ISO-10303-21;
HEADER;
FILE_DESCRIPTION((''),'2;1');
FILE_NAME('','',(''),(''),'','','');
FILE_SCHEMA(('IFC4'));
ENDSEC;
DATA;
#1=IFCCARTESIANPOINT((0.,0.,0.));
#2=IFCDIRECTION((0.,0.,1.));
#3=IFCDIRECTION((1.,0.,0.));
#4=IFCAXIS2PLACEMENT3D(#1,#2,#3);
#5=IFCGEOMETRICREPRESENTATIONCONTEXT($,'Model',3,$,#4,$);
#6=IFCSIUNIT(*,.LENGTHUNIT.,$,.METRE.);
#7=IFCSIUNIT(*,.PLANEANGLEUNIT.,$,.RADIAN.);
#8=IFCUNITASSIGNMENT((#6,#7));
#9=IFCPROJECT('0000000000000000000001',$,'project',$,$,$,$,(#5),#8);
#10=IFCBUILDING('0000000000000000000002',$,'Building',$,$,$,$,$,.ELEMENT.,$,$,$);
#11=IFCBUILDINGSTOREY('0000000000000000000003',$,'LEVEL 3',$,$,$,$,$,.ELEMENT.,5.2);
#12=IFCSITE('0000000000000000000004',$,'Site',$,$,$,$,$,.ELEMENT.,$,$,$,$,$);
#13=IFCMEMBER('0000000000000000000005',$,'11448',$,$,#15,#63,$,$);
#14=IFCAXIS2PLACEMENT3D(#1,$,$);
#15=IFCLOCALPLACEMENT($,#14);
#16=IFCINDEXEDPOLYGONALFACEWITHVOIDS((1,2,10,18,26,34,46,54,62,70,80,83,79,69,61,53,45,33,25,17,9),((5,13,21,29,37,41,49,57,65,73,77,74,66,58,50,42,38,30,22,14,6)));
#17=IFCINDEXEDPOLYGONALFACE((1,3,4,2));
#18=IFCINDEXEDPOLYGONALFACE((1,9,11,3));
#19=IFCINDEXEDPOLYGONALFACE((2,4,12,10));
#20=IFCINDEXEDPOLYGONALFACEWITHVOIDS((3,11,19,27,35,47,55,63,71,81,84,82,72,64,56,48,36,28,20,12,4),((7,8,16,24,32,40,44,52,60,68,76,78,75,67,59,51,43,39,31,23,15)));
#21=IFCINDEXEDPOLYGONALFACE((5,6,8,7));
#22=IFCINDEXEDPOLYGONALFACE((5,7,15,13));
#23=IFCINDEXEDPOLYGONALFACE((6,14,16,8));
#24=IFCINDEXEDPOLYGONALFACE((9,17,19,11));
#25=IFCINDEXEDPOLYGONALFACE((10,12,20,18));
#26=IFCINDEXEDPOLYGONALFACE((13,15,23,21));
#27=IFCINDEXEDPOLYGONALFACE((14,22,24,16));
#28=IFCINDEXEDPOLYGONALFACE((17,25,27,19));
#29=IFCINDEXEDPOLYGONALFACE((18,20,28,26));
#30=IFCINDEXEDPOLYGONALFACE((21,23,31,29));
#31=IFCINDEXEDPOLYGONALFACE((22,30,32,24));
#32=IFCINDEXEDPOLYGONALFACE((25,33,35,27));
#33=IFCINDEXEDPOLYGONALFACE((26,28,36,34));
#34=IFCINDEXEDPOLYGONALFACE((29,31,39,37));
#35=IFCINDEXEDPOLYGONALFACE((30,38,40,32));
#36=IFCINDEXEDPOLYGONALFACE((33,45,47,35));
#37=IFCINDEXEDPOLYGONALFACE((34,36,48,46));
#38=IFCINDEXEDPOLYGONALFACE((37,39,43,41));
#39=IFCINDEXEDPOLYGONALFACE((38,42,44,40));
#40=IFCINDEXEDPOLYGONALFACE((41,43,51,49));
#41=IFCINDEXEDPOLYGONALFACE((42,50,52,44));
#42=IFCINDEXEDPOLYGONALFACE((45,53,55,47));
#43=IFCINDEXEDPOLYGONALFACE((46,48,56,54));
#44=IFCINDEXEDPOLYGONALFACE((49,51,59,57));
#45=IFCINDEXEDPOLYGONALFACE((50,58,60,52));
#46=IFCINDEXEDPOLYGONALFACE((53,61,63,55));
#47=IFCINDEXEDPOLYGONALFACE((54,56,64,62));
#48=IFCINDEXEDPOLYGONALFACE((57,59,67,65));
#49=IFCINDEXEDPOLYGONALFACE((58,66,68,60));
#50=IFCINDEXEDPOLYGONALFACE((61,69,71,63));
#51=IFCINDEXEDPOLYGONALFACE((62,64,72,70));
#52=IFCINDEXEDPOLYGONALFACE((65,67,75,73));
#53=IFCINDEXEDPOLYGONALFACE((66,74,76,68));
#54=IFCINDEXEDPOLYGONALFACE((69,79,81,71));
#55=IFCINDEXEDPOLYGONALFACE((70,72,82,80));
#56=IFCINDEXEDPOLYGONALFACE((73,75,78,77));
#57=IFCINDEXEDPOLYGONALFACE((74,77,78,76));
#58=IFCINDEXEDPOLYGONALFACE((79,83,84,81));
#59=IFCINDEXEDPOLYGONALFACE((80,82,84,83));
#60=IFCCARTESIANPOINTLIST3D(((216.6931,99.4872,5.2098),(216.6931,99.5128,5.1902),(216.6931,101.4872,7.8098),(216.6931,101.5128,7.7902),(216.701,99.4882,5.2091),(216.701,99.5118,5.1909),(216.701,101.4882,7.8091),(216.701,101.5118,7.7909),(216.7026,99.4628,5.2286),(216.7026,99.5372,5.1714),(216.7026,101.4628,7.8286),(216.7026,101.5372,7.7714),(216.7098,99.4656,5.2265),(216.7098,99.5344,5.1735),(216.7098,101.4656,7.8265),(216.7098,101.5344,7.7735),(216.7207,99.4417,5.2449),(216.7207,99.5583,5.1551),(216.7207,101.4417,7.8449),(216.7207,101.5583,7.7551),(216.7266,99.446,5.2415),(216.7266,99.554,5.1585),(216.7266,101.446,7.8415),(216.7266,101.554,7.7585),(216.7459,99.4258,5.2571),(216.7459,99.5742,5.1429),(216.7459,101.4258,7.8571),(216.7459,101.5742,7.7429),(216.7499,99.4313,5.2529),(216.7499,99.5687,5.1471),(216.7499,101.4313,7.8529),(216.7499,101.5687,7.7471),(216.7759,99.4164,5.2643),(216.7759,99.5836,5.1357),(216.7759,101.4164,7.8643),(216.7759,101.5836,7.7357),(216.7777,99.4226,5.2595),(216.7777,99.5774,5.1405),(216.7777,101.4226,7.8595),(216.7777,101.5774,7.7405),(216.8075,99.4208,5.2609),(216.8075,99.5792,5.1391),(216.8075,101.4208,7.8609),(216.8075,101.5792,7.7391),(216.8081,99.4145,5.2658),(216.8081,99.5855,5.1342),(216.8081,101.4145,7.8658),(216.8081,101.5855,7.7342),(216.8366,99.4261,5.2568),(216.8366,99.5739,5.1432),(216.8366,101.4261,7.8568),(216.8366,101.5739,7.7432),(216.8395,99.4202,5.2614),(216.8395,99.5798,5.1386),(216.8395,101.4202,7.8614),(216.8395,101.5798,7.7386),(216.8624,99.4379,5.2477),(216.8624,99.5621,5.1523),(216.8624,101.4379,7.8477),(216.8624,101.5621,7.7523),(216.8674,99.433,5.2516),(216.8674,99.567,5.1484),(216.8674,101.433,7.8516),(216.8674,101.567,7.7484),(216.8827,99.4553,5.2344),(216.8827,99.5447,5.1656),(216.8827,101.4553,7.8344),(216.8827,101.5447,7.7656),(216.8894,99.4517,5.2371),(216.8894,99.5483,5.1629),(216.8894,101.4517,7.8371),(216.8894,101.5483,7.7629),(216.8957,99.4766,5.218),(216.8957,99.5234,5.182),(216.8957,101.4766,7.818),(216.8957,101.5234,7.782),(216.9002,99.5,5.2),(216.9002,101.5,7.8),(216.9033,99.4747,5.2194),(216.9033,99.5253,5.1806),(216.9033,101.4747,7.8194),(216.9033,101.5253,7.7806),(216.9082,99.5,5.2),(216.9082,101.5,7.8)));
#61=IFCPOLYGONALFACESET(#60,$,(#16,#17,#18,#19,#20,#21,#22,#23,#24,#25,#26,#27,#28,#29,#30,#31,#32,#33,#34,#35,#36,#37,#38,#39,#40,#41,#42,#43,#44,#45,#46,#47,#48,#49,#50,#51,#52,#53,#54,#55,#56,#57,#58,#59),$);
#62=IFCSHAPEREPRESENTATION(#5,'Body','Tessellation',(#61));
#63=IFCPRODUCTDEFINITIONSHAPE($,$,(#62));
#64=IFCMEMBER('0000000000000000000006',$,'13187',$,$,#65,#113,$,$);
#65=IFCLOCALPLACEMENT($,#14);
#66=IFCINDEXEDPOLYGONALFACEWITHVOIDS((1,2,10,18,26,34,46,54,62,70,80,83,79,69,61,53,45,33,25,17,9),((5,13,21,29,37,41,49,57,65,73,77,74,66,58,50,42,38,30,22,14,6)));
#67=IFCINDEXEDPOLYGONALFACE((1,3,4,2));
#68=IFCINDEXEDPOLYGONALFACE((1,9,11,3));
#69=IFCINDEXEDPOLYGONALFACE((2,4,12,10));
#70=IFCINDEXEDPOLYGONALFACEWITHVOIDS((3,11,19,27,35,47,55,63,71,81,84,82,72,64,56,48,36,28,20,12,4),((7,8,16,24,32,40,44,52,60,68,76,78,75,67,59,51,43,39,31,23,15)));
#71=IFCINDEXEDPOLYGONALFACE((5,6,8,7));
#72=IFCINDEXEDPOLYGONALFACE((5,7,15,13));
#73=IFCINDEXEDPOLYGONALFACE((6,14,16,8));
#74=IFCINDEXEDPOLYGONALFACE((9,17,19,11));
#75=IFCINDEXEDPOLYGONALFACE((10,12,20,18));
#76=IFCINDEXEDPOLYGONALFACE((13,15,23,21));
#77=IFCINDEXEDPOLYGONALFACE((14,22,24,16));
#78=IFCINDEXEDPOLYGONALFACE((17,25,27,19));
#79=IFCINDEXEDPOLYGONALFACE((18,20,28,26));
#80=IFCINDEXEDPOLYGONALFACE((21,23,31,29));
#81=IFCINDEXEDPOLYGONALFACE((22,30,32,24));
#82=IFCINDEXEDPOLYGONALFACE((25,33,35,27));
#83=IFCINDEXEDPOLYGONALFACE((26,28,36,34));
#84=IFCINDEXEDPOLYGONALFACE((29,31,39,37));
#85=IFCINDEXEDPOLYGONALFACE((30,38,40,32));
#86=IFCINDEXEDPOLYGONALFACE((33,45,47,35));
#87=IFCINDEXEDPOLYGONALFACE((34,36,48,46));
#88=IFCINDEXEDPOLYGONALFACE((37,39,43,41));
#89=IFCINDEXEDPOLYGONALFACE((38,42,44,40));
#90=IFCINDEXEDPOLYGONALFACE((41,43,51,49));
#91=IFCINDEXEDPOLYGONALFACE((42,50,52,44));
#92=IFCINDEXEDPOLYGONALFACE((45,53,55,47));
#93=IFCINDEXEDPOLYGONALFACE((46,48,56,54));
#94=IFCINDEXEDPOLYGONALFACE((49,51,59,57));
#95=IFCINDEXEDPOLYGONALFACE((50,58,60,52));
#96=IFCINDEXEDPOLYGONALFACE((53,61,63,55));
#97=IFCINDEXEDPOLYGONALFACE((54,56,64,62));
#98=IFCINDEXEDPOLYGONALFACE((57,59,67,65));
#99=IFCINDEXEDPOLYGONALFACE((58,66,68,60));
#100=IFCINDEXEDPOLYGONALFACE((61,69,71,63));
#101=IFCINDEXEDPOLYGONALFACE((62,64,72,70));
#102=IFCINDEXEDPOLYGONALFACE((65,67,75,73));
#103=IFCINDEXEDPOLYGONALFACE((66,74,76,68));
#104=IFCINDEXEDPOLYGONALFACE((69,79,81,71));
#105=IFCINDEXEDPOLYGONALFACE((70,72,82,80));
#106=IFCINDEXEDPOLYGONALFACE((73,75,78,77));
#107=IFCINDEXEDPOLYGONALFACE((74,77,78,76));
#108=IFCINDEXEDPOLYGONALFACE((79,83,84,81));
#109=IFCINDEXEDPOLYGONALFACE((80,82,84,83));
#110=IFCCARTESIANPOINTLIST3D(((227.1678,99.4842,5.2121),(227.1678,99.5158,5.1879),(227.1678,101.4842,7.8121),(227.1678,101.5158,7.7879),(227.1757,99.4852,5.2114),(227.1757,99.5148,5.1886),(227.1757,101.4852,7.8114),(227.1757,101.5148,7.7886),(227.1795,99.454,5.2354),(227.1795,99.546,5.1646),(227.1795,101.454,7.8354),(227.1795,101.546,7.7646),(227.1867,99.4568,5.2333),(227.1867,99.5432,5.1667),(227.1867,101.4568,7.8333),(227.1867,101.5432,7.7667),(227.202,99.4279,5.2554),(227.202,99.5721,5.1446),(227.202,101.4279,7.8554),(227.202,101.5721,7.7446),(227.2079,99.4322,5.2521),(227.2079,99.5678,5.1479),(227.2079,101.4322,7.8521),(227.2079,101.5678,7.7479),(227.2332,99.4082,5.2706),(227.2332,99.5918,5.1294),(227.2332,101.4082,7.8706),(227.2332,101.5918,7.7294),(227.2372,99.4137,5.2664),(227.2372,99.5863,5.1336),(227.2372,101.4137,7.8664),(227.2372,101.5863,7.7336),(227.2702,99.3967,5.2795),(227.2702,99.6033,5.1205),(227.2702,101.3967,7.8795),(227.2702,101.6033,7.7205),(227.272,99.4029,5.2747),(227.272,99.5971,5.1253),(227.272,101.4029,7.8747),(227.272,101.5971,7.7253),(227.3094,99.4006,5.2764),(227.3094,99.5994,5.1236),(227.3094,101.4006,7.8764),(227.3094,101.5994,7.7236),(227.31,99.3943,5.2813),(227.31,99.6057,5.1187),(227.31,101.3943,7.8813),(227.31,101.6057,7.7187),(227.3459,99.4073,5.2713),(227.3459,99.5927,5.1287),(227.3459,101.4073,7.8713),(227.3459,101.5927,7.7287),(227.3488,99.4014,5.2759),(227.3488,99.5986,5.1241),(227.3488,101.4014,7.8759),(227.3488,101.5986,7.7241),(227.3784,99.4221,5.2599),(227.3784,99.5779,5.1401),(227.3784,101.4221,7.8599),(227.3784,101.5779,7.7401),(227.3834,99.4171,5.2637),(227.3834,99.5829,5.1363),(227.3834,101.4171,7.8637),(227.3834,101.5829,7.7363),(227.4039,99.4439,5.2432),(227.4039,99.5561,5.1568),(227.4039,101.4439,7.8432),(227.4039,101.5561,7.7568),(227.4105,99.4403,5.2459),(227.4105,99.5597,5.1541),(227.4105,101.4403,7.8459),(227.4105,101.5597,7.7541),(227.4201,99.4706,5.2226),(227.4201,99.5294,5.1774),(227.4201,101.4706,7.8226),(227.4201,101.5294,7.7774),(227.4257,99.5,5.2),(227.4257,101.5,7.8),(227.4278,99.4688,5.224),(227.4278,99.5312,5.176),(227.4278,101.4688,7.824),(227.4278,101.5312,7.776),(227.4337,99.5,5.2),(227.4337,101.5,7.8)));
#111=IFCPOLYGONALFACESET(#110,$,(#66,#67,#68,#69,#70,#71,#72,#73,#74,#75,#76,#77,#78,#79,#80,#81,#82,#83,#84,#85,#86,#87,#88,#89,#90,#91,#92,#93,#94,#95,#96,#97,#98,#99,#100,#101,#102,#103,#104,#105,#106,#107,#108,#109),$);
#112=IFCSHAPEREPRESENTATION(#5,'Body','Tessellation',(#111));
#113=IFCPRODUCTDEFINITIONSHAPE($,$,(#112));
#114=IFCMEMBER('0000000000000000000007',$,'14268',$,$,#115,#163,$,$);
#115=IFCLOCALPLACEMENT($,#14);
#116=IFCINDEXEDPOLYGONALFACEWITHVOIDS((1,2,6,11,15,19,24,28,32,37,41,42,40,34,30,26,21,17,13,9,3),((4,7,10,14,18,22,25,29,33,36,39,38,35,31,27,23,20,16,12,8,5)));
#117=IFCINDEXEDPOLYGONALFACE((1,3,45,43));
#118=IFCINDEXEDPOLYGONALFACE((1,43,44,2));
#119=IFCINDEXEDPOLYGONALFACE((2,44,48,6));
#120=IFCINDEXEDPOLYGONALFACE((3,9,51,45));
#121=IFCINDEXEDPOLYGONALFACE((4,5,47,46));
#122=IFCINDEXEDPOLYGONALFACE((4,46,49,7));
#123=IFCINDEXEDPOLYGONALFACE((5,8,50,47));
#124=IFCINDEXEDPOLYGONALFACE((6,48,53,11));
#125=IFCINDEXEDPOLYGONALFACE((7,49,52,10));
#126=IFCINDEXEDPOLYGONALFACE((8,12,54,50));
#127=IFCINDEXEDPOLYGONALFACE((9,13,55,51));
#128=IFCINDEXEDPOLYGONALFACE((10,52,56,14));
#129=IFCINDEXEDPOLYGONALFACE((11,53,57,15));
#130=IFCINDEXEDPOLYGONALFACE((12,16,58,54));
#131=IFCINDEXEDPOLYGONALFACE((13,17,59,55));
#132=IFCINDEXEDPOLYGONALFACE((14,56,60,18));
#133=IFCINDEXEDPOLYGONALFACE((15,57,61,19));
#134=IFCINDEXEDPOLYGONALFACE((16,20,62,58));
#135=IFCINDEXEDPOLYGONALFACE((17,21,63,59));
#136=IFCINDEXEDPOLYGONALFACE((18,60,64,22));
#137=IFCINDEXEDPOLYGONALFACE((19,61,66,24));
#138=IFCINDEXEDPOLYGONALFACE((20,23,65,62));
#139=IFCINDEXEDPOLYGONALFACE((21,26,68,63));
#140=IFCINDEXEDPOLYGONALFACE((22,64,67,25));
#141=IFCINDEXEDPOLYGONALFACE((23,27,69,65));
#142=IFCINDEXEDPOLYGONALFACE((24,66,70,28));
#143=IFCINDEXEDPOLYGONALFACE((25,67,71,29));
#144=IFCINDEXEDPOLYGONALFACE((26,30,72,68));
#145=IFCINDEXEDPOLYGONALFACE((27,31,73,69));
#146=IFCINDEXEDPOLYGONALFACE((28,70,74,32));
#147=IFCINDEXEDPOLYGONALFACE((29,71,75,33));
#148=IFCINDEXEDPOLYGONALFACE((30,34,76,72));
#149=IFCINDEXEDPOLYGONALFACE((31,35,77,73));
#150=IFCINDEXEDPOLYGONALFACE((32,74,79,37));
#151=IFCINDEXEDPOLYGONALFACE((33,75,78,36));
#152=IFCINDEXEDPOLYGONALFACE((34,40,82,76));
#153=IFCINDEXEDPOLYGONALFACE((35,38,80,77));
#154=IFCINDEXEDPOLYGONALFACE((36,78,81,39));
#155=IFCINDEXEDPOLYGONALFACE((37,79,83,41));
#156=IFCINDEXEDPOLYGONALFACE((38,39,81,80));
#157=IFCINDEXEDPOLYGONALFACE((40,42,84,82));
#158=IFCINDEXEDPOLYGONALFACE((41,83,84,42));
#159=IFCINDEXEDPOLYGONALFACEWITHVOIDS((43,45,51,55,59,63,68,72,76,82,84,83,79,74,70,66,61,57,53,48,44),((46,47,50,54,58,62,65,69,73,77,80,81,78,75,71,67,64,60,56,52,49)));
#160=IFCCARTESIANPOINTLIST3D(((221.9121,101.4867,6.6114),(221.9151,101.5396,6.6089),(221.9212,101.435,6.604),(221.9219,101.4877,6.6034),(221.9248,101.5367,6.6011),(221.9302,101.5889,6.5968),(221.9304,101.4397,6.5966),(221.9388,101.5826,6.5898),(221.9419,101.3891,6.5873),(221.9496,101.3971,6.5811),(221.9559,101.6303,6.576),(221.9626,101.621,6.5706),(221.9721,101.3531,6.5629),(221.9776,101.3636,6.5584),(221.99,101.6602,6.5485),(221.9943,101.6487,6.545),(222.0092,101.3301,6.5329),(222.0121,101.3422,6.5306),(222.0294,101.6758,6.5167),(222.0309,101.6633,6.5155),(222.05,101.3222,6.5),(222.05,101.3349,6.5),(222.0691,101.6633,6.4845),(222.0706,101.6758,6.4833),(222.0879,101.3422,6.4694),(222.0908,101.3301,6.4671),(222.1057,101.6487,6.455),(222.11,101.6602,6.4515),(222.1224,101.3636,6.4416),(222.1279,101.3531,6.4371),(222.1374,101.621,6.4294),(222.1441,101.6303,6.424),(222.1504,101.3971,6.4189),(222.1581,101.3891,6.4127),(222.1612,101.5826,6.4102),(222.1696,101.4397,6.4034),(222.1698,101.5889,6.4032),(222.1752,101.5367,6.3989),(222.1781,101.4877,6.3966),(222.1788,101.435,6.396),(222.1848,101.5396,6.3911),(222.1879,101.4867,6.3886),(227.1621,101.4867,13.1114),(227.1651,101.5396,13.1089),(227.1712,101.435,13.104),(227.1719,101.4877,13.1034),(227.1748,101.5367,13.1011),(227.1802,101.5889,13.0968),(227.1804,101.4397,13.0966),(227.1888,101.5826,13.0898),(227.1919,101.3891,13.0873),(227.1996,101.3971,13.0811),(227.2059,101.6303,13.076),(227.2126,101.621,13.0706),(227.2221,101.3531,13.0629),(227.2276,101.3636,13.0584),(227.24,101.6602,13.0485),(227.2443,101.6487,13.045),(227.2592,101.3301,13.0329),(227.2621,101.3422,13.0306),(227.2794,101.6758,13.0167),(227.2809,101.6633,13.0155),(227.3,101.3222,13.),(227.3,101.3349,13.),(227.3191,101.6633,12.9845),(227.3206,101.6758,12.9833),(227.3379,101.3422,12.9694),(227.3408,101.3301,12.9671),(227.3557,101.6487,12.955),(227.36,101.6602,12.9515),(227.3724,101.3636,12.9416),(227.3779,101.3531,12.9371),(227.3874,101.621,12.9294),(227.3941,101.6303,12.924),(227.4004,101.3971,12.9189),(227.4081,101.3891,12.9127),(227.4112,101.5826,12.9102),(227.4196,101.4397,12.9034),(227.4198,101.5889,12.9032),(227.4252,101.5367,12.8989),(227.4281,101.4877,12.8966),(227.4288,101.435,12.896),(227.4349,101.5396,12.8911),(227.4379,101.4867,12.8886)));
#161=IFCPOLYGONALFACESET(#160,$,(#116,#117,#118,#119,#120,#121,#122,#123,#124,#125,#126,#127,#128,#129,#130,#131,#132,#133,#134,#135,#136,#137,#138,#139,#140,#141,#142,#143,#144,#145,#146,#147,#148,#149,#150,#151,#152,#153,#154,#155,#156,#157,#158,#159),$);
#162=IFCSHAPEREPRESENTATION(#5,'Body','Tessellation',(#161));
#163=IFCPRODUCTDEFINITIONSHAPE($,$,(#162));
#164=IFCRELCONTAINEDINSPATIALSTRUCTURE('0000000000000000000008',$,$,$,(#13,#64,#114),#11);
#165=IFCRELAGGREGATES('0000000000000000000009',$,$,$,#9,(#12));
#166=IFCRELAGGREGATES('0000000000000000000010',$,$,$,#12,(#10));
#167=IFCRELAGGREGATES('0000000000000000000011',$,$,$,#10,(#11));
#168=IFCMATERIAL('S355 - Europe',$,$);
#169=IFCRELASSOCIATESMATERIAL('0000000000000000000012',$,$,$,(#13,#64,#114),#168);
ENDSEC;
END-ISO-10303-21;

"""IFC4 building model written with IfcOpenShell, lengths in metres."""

from ifc_helpers import new_model, si_unit, frame, origin_with_axes, origin_2d_with_axis, place, context, project, spatial, hollow_circle, extrude, material, material_profile, profile_set, profile_usage, element, save


model = new_model("IFC4")

# Units and contexts
model_context = context("Model", 3, world=origin_with_axes())
ifc_project = project(units=[si_unit("LENGTHUNIT", "METRE"), si_unit("PLANEANGLEUNIT", "RADIAN")], contexts=[model_context])

# Site, building, storey
site = spatial("IfcSite", under=ifc_project, Name="Site", CompositionType="ELEMENT")
building = spatial("IfcBuilding", under=site, Name="Building", CompositionType="ELEMENT")
storey = spatial("IfcBuildingStorey", under=building, Name="LEVEL 3", CompositionType="ELEMENT", Elevation=5.2)

# Shared definitions
ifc_material = material(Name="S355 - Europe")

# Members
ifc_material_profile_1 = material_profile(ifc_material, hollow_circle(Radius=0.1081, WallThickness=0.008, at=origin_2d_with_axis()))
ifc_profile_set_1 = profile_set([ifc_material_profile_1])
ifc_profile_usage_1 = profile_usage(ifc_profile_set_1, cardinal=10)
member_1_placement = place(None, frame((216.8, 101.5, 7.8), z_axis=(0.0, -0.609711, -0.792624), x_axis=(1.0, 0.0, 0.0)))
element("IfcMember", 1, at=member_1_placement, inside=storey, material=ifc_profile_usage_1, Name="11448", context=model_context, shape_type="SweptSolid", body=[
    extrude(hollow_circle(Radius=0.1081, WallThickness=0.008, at=origin_2d_with_axis()), origin_with_axes(), (0.0, 0.0, 1.0), 3.2802),
])
ifc_material_profile_2 = material_profile(ifc_material, hollow_circle(Radius=0.1337, WallThickness=0.008, at=origin_2d_with_axis()))
ifc_profile_set_2 = profile_set([ifc_material_profile_2])
ifc_profile_usage_2 = profile_usage(ifc_profile_set_2, cardinal=10)
member_2_placement = place(None, frame((227.3, 101.5, 7.8), z_axis=(0.0, -0.609711, -0.792624), x_axis=(1.0, 0.0, 0.0)))
element("IfcMember", 2, at=member_2_placement, inside=storey, material=ifc_profile_usage_2, Name="13187", context=model_context, shape_type="SweptSolid", body=[
    extrude(hollow_circle(Radius=0.1337, WallThickness=0.008, at=origin_2d_with_axis()), origin_with_axes(), (0.0, 0.0, 1.0), 3.2802),
])
ifc_material_profile_3 = material_profile(ifc_material, hollow_circle(Radius=0.1778, WallThickness=0.0127, at=origin_2d_with_axis()))
ifc_profile_set_3 = profile_set([ifc_material_profile_3])
ifc_profile_usage_3 = profile_usage(ifc_profile_set_3, cardinal=10)
member_3_placement = place(None, frame((227.3, 101.5, 13.0), z_axis=(-0.628337, 0.0, -0.777941), x_axis=(0.0, -1.0, 0.0)))
element("IfcMember", 3, at=member_3_placement, inside=storey, material=ifc_profile_usage_3, Name="14268", context=model_context, shape_type="SweptSolid", body=[
    extrude(hollow_circle(Radius=0.1778, WallThickness=0.0127, at=origin_2d_with_axis()), origin_with_axes(), (0.0, 0.0, 1.0), 8.3554),
])

save(model, "model.ifc")
